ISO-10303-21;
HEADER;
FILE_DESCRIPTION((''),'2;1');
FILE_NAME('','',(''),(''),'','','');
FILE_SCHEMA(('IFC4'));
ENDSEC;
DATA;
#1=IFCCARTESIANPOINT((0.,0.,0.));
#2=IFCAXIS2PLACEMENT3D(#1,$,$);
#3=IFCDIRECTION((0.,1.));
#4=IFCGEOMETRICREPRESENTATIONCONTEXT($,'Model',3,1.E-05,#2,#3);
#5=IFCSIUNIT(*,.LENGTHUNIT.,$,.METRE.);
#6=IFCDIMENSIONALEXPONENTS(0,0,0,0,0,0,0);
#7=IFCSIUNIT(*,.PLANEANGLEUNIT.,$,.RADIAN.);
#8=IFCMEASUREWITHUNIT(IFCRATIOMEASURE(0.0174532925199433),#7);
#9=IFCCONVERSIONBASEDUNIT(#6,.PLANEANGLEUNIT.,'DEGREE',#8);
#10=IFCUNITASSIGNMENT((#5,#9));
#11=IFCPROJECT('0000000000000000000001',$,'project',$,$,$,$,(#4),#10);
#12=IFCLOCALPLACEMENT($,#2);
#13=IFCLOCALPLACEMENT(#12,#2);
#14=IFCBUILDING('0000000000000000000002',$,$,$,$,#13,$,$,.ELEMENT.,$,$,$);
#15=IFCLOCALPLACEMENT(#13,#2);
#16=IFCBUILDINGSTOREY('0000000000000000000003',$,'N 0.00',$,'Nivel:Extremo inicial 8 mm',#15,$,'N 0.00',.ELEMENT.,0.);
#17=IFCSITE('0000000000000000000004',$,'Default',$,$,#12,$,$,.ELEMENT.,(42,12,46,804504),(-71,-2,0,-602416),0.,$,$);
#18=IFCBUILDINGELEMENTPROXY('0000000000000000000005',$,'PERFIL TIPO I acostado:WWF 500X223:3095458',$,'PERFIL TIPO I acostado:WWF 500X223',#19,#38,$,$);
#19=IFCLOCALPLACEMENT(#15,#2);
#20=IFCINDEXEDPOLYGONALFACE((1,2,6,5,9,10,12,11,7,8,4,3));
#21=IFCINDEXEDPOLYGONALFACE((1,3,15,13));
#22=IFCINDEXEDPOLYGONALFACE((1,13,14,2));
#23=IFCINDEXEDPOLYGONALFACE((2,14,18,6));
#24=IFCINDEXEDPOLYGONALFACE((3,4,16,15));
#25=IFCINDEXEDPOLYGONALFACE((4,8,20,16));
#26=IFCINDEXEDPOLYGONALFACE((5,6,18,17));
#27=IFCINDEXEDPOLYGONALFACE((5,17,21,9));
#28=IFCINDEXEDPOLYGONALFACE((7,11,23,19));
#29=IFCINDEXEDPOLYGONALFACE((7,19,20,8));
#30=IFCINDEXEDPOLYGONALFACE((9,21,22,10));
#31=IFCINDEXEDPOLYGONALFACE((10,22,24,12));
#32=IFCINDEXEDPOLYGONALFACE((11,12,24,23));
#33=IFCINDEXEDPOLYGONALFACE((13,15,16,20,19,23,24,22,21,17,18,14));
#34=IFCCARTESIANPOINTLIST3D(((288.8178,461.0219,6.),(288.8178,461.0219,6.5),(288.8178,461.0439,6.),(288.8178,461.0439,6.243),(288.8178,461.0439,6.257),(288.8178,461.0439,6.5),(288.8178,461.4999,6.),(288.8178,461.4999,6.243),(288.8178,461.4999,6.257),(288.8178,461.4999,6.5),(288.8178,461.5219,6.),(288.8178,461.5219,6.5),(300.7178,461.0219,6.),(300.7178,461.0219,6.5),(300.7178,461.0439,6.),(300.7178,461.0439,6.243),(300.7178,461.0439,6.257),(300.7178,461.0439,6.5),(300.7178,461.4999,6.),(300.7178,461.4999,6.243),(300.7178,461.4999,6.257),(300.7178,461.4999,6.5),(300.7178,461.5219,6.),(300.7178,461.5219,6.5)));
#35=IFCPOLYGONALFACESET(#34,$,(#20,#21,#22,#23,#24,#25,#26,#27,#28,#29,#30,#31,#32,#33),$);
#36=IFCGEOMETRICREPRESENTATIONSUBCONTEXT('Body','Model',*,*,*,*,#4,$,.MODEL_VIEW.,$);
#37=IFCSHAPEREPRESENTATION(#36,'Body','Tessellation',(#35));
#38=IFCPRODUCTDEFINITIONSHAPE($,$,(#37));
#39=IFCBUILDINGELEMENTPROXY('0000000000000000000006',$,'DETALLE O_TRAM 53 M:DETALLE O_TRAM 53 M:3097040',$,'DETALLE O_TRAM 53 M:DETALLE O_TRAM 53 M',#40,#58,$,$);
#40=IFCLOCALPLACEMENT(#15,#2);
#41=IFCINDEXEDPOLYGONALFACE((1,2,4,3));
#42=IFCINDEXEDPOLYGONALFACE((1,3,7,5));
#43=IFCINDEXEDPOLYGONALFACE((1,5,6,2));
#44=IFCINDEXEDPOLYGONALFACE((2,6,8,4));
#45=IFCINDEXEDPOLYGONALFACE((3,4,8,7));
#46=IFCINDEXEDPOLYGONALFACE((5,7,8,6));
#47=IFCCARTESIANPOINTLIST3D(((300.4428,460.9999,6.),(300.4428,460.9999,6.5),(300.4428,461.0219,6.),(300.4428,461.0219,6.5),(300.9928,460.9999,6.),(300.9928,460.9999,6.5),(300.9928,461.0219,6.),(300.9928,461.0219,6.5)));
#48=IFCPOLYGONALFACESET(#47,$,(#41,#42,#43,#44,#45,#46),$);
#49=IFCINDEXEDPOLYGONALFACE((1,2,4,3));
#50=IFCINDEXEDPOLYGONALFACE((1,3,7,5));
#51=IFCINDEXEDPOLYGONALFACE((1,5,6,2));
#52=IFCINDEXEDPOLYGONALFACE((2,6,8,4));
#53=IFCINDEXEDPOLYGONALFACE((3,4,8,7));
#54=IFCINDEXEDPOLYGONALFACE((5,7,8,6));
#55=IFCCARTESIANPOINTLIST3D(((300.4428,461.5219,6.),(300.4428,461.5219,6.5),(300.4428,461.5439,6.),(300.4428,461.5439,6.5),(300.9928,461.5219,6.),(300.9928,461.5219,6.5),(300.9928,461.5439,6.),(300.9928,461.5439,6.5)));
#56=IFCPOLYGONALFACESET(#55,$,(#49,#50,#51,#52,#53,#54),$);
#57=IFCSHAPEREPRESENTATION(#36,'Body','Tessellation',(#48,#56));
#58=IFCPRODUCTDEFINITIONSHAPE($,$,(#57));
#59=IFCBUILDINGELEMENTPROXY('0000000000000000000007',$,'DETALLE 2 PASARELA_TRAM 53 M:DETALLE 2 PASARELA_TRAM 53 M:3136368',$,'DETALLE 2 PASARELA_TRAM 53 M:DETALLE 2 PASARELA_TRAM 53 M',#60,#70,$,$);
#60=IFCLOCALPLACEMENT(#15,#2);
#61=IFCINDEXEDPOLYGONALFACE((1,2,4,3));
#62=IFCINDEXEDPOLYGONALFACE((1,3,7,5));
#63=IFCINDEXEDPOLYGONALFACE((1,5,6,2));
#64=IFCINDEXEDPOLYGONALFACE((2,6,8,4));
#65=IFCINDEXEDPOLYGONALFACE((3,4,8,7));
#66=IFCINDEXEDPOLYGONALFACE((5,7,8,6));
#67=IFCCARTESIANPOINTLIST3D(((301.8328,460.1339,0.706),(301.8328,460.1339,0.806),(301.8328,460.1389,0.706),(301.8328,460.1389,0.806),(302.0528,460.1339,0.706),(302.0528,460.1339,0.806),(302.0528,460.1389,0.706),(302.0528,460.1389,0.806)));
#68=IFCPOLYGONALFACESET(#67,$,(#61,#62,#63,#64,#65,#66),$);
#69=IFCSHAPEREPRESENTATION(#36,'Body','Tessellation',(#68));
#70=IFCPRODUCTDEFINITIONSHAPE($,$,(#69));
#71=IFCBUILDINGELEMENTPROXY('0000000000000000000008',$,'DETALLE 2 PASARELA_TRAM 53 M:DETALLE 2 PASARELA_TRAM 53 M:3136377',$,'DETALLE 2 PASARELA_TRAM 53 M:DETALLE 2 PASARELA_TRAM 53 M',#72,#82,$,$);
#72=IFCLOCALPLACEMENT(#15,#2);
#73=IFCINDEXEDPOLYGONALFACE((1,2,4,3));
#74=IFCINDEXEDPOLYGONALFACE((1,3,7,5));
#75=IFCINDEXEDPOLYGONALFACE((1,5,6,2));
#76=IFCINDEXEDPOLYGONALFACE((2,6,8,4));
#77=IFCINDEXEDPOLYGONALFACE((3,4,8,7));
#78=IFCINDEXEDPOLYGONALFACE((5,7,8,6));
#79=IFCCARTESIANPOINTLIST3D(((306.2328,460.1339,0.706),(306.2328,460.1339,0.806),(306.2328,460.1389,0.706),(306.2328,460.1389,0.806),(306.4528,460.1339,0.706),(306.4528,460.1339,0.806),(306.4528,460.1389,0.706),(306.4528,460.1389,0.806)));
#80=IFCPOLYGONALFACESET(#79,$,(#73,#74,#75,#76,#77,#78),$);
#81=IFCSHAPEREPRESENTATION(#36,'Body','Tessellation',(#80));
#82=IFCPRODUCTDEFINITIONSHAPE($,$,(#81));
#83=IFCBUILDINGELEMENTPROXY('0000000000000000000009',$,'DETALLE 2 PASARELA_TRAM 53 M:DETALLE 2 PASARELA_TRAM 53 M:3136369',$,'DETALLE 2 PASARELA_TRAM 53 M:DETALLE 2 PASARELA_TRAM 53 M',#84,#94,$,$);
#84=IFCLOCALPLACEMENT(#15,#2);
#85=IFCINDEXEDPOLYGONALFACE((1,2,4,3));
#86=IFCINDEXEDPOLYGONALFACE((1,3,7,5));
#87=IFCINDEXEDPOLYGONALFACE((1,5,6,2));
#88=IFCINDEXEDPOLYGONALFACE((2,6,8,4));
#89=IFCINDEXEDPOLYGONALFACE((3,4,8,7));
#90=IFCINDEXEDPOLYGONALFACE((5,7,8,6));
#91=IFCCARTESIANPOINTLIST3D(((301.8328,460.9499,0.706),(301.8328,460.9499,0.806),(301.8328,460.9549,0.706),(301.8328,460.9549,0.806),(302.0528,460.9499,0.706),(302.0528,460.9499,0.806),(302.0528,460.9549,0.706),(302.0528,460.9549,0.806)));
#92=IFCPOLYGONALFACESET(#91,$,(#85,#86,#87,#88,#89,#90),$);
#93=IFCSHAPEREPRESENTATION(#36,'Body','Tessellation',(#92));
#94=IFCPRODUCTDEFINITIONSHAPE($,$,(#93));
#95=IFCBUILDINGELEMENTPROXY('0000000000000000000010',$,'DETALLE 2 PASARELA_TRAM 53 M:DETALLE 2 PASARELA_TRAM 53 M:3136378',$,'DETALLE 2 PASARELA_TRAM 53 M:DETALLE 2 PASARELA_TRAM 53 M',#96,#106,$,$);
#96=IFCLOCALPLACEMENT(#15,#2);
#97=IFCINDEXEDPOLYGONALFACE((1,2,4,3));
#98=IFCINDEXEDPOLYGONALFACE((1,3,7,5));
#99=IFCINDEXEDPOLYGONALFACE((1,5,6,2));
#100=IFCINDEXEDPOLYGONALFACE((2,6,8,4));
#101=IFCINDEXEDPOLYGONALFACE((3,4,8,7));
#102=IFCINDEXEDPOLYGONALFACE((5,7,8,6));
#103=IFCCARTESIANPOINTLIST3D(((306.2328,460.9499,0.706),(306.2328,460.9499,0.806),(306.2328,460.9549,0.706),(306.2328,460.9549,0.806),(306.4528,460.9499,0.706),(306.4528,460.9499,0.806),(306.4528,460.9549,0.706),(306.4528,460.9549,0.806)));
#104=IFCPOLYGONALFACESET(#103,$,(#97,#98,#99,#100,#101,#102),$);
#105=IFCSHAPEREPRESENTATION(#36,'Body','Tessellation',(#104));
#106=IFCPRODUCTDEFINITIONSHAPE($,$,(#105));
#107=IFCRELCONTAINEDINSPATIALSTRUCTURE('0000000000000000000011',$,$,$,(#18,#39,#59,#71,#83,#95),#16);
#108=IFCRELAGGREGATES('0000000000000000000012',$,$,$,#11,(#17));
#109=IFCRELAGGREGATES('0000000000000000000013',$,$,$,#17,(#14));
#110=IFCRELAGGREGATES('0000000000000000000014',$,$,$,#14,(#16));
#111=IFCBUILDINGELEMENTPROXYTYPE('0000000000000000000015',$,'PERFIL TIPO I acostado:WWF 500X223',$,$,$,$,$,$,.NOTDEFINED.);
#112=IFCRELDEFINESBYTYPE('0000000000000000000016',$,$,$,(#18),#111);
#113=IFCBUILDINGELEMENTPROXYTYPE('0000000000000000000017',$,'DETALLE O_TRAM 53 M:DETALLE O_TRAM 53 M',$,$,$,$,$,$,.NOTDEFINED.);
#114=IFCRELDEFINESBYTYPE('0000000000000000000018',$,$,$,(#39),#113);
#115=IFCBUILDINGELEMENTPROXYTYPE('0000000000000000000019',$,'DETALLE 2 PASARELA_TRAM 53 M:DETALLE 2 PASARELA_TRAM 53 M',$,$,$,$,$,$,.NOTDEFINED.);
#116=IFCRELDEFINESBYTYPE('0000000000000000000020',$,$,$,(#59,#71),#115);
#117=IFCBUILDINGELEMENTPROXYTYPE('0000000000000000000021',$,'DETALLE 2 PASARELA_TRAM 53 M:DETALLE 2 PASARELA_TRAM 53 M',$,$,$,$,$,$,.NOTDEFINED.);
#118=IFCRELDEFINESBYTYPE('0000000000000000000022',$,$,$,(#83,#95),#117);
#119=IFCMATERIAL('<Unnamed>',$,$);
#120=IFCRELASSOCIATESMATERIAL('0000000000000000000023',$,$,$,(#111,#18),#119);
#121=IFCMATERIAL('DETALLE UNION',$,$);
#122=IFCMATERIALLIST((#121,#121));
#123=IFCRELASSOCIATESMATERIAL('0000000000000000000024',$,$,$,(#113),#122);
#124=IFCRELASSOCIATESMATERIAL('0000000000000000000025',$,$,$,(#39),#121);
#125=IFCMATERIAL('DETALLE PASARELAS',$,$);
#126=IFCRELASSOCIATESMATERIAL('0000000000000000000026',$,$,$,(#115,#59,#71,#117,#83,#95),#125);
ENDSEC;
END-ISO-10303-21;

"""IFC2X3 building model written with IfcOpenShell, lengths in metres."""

from ifc_helpers import new_model, entity, si_unit, converted_unit, direction, frame, frame_2d, origin, place, context, subcontext, project, spatial, polyline, rectangle, outline, extrude, source, transform, mapped, material, material_list, type_object, type_shapes, element, save


model = new_model("IFC2X3")

# Units and contexts
model_context = context("Model", 3, precision=1e-05, world=origin(), true_north=direction((0.0, 1.0)))
body_context = subcontext(model_context, "Body", "Model", "MODEL_VIEW")
ifc_project = project(units=[si_unit("LENGTHUNIT", "METRE"), converted_unit("PLANEANGLEUNIT", "DEGREE", entity("IfcRatioMeasure", 0.0174532925199433), si_unit("PLANEANGLEUNIT", "RADIAN"), dimensions=[0, 0, 0, 0, 0, 0, 0])], contexts=[model_context])

# Site, building, storey
site_placement = place(None, origin())
site = spatial("IfcSite", under=ifc_project, at=site_placement, Name="Default", CompositionType="ELEMENT", RefLatitude=(42, 12, 46, 804504), RefLongitude=(-71, -2, 0, -602416), RefElevation=0.0)
building_placement = place(site_placement, origin())
building = spatial("IfcBuilding", under=site, at=building_placement, CompositionType="ELEMENT")
storey_placement = place(building_placement, origin())
storey = spatial("IfcBuildingStorey", under=building, at=storey_placement, Name="N 0.00", ObjectType="Nivel:Extremo inicial 8 mm", LongName="N 0.00", CompositionType="ELEMENT", Elevation=0.0)

# Building element proxies
ifc_material_1 = material(Name="DETALLE UNION")
ifc_material_2 = material(Name="<Unnamed>")
building_element_proxy_type_1 = type_object("IfcBuildingElementProxyType", Name="PERFIL TIPO I acostado:WWF 500X223", PredefinedType="NOTDEFINED", material=ifc_material_2)
shared_shape_1 = source(origin(), body_context, "Body", "SweptSolid", [
    extrude(outline(polyline([(0.228, -0.25), (0.25, -0.25), (0.25, 0.25), (0.228, 0.25), (0.228, 0.007), (-0.228, 0.007), (-0.228, 0.25), (-0.25, 0.25), (-0.25, -0.25), (-0.228, -0.25), (-0.228, -0.007), (0.228, -0.007), (0.228, -0.25)])), frame((0.0, 0.0, 0.25), z_axis=(1.0, 0.0, 0.0), x_axis=(0.0, -1.0, 0.0)), (0.0, 0.0, 1.0), 11.9),
])
type_shapes(building_element_proxy_type_1, [shared_shape_1])
proxy_1_placement = place(storey_placement, frame((300.7178, 461.2719, 6.0), z_axis=(0.0, 0.0, 1.0), x_axis=(-1.0, 0.0, 0.0)))
element("IfcBuildingElementProxy", 1, at=proxy_1_placement, inside=storey, type_object=building_element_proxy_type_1, material=ifc_material_2, Name="PERFIL TIPO I acostado:WWF 500X223:3095458", ObjectType="PERFIL TIPO I acostado:WWF 500X223", context=body_context, shape_type="MappedRepresentation", body=[
    mapped(shared_shape_1, transform((0.0, 0.0, 0.0), scale=1.0)),
])
ifc_material_list_1 = material_list([ifc_material_1, ifc_material_1])
building_element_proxy_type_2 = type_object("IfcBuildingElementProxyType", Name="DETALLE O_TRAM 53 M:DETALLE O_TRAM 53 M", PredefinedType="NOTDEFINED", material=ifc_material_list_1)
shared_shape_2 = source(origin(), body_context, "Body", "SweptSolid", [
    extrude(rectangle(XDim=0.022, YDim=0.55, at=frame_2d((0.0, 0.0), x_axis=(1.0, 0.0))), frame((0.275, -0.011, 0.0), z_axis=(0.0, 0.0, 1.0), x_axis=(0.0, 1.0, 0.0)), (0.0, 0.0, 1.0), 0.5),
    extrude(rectangle(XDim=0.022, YDim=0.55, at=frame_2d((0.0, 0.0), x_axis=(1.0, 0.0))), frame((0.275, 0.511, 0.0), z_axis=(0.0, 0.0, 1.0), x_axis=(0.0, 1.0, 0.0)), (0.0, 0.0, 1.0), 0.5),
])
type_shapes(building_element_proxy_type_2, [shared_shape_2])
proxy_2_placement = place(storey_placement, frame((300.4428, 461.0219, 6.0)))
element("IfcBuildingElementProxy", 2, at=proxy_2_placement, inside=storey, type_object=building_element_proxy_type_2, material=ifc_material_1, Name="DETALLE O_TRAM 53 M:DETALLE O_TRAM 53 M:3097040", ObjectType="DETALLE O_TRAM 53 M:DETALLE O_TRAM 53 M", context=body_context, shape_type="MappedRepresentation", body=[
    mapped(shared_shape_2, transform((0.0, 0.0, 0.0), scale=1.0)),
])
ifc_material_3 = material(Name="DETALLE PASARELAS")
building_element_proxy_type_3 = type_object("IfcBuildingElementProxyType", Name="DETALLE 2 PASARELA_TRAM 53 M:DETALLE 2 PASARELA_TRAM 53 M", PredefinedType="NOTDEFINED", material=ifc_material_3)
shared_shape_3 = source(origin(), body_context, "Body", "SweptSolid", [
    extrude(rectangle(XDim=0.22, YDim=0.005, at=frame_2d((0.0, 0.0), x_axis=(1.0, 0.0))), frame((0.11, 0.0475, 0.0), z_axis=(0.0, 0.0, 1.0), x_axis=(-1.0, 0.0, 0.0)), (0.0, 0.0, 1.0), 0.1),
])
type_shapes(building_element_proxy_type_3, [shared_shape_3])
for number, where, name in (
    (3, (301.8328, 460.0889, 0.706), "DETALLE 2 PASARELA_TRAM 53 M:DETALLE 2 PASARELA_TRAM 53 M:3136368"),
    (4, (306.2328, 460.0889, 0.706), "DETALLE 2 PASARELA_TRAM 53 M:DETALLE 2 PASARELA_TRAM 53 M:3136377"),
):
    element("IfcBuildingElementProxy", number, at=place(storey_placement, frame(where)), inside=storey, type_object=building_element_proxy_type_3, material=ifc_material_3, Name=name, ObjectType="DETALLE 2 PASARELA_TRAM 53 M:DETALLE 2 PASARELA_TRAM 53 M", context=body_context, shape_type="MappedRepresentation", body=[
        mapped(shared_shape_3, transform((0.0, 0.0, 0.0), scale=1.0)),
    ])
building_element_proxy_type_4 = type_object("IfcBuildingElementProxyType", Name="DETALLE 2 PASARELA_TRAM 53 M:DETALLE 2 PASARELA_TRAM 53 M", PredefinedType="NOTDEFINED", material=ifc_material_3)
shared_shape_4 = source(origin(), body_context, "Body", "SweptSolid", [
    extrude(rectangle(XDim=0.005, YDim=0.22, at=frame_2d((0.0, 0.0), x_axis=(1.0, 0.0))), frame((0.11, -0.0475, 0.0), z_axis=(0.0, 0.0, 1.0), x_axis=(0.0, 1.0, 0.0)), (0.0, 0.0, 1.0), 0.1),
])
type_shapes(building_element_proxy_type_4, [shared_shape_4])
for number, where, name in (
    (5, (301.8328, 460.9999, 0.706), "DETALLE 2 PASARELA_TRAM 53 M:DETALLE 2 PASARELA_TRAM 53 M:3136369"),
    (6, (306.2328, 460.9999, 0.706), "DETALLE 2 PASARELA_TRAM 53 M:DETALLE 2 PASARELA_TRAM 53 M:3136378"),
):
    element("IfcBuildingElementProxy", number, at=place(storey_placement, frame(where)), inside=storey, type_object=building_element_proxy_type_4, material=ifc_material_3, Name=name, ObjectType="DETALLE 2 PASARELA_TRAM 53 M:DETALLE 2 PASARELA_TRAM 53 M", context=body_context, shape_type="MappedRepresentation", body=[
        mapped(shared_shape_4, transform((0.0, 0.0, 0.0), scale=1.0)),
    ])

save(model, "model.ifc")
